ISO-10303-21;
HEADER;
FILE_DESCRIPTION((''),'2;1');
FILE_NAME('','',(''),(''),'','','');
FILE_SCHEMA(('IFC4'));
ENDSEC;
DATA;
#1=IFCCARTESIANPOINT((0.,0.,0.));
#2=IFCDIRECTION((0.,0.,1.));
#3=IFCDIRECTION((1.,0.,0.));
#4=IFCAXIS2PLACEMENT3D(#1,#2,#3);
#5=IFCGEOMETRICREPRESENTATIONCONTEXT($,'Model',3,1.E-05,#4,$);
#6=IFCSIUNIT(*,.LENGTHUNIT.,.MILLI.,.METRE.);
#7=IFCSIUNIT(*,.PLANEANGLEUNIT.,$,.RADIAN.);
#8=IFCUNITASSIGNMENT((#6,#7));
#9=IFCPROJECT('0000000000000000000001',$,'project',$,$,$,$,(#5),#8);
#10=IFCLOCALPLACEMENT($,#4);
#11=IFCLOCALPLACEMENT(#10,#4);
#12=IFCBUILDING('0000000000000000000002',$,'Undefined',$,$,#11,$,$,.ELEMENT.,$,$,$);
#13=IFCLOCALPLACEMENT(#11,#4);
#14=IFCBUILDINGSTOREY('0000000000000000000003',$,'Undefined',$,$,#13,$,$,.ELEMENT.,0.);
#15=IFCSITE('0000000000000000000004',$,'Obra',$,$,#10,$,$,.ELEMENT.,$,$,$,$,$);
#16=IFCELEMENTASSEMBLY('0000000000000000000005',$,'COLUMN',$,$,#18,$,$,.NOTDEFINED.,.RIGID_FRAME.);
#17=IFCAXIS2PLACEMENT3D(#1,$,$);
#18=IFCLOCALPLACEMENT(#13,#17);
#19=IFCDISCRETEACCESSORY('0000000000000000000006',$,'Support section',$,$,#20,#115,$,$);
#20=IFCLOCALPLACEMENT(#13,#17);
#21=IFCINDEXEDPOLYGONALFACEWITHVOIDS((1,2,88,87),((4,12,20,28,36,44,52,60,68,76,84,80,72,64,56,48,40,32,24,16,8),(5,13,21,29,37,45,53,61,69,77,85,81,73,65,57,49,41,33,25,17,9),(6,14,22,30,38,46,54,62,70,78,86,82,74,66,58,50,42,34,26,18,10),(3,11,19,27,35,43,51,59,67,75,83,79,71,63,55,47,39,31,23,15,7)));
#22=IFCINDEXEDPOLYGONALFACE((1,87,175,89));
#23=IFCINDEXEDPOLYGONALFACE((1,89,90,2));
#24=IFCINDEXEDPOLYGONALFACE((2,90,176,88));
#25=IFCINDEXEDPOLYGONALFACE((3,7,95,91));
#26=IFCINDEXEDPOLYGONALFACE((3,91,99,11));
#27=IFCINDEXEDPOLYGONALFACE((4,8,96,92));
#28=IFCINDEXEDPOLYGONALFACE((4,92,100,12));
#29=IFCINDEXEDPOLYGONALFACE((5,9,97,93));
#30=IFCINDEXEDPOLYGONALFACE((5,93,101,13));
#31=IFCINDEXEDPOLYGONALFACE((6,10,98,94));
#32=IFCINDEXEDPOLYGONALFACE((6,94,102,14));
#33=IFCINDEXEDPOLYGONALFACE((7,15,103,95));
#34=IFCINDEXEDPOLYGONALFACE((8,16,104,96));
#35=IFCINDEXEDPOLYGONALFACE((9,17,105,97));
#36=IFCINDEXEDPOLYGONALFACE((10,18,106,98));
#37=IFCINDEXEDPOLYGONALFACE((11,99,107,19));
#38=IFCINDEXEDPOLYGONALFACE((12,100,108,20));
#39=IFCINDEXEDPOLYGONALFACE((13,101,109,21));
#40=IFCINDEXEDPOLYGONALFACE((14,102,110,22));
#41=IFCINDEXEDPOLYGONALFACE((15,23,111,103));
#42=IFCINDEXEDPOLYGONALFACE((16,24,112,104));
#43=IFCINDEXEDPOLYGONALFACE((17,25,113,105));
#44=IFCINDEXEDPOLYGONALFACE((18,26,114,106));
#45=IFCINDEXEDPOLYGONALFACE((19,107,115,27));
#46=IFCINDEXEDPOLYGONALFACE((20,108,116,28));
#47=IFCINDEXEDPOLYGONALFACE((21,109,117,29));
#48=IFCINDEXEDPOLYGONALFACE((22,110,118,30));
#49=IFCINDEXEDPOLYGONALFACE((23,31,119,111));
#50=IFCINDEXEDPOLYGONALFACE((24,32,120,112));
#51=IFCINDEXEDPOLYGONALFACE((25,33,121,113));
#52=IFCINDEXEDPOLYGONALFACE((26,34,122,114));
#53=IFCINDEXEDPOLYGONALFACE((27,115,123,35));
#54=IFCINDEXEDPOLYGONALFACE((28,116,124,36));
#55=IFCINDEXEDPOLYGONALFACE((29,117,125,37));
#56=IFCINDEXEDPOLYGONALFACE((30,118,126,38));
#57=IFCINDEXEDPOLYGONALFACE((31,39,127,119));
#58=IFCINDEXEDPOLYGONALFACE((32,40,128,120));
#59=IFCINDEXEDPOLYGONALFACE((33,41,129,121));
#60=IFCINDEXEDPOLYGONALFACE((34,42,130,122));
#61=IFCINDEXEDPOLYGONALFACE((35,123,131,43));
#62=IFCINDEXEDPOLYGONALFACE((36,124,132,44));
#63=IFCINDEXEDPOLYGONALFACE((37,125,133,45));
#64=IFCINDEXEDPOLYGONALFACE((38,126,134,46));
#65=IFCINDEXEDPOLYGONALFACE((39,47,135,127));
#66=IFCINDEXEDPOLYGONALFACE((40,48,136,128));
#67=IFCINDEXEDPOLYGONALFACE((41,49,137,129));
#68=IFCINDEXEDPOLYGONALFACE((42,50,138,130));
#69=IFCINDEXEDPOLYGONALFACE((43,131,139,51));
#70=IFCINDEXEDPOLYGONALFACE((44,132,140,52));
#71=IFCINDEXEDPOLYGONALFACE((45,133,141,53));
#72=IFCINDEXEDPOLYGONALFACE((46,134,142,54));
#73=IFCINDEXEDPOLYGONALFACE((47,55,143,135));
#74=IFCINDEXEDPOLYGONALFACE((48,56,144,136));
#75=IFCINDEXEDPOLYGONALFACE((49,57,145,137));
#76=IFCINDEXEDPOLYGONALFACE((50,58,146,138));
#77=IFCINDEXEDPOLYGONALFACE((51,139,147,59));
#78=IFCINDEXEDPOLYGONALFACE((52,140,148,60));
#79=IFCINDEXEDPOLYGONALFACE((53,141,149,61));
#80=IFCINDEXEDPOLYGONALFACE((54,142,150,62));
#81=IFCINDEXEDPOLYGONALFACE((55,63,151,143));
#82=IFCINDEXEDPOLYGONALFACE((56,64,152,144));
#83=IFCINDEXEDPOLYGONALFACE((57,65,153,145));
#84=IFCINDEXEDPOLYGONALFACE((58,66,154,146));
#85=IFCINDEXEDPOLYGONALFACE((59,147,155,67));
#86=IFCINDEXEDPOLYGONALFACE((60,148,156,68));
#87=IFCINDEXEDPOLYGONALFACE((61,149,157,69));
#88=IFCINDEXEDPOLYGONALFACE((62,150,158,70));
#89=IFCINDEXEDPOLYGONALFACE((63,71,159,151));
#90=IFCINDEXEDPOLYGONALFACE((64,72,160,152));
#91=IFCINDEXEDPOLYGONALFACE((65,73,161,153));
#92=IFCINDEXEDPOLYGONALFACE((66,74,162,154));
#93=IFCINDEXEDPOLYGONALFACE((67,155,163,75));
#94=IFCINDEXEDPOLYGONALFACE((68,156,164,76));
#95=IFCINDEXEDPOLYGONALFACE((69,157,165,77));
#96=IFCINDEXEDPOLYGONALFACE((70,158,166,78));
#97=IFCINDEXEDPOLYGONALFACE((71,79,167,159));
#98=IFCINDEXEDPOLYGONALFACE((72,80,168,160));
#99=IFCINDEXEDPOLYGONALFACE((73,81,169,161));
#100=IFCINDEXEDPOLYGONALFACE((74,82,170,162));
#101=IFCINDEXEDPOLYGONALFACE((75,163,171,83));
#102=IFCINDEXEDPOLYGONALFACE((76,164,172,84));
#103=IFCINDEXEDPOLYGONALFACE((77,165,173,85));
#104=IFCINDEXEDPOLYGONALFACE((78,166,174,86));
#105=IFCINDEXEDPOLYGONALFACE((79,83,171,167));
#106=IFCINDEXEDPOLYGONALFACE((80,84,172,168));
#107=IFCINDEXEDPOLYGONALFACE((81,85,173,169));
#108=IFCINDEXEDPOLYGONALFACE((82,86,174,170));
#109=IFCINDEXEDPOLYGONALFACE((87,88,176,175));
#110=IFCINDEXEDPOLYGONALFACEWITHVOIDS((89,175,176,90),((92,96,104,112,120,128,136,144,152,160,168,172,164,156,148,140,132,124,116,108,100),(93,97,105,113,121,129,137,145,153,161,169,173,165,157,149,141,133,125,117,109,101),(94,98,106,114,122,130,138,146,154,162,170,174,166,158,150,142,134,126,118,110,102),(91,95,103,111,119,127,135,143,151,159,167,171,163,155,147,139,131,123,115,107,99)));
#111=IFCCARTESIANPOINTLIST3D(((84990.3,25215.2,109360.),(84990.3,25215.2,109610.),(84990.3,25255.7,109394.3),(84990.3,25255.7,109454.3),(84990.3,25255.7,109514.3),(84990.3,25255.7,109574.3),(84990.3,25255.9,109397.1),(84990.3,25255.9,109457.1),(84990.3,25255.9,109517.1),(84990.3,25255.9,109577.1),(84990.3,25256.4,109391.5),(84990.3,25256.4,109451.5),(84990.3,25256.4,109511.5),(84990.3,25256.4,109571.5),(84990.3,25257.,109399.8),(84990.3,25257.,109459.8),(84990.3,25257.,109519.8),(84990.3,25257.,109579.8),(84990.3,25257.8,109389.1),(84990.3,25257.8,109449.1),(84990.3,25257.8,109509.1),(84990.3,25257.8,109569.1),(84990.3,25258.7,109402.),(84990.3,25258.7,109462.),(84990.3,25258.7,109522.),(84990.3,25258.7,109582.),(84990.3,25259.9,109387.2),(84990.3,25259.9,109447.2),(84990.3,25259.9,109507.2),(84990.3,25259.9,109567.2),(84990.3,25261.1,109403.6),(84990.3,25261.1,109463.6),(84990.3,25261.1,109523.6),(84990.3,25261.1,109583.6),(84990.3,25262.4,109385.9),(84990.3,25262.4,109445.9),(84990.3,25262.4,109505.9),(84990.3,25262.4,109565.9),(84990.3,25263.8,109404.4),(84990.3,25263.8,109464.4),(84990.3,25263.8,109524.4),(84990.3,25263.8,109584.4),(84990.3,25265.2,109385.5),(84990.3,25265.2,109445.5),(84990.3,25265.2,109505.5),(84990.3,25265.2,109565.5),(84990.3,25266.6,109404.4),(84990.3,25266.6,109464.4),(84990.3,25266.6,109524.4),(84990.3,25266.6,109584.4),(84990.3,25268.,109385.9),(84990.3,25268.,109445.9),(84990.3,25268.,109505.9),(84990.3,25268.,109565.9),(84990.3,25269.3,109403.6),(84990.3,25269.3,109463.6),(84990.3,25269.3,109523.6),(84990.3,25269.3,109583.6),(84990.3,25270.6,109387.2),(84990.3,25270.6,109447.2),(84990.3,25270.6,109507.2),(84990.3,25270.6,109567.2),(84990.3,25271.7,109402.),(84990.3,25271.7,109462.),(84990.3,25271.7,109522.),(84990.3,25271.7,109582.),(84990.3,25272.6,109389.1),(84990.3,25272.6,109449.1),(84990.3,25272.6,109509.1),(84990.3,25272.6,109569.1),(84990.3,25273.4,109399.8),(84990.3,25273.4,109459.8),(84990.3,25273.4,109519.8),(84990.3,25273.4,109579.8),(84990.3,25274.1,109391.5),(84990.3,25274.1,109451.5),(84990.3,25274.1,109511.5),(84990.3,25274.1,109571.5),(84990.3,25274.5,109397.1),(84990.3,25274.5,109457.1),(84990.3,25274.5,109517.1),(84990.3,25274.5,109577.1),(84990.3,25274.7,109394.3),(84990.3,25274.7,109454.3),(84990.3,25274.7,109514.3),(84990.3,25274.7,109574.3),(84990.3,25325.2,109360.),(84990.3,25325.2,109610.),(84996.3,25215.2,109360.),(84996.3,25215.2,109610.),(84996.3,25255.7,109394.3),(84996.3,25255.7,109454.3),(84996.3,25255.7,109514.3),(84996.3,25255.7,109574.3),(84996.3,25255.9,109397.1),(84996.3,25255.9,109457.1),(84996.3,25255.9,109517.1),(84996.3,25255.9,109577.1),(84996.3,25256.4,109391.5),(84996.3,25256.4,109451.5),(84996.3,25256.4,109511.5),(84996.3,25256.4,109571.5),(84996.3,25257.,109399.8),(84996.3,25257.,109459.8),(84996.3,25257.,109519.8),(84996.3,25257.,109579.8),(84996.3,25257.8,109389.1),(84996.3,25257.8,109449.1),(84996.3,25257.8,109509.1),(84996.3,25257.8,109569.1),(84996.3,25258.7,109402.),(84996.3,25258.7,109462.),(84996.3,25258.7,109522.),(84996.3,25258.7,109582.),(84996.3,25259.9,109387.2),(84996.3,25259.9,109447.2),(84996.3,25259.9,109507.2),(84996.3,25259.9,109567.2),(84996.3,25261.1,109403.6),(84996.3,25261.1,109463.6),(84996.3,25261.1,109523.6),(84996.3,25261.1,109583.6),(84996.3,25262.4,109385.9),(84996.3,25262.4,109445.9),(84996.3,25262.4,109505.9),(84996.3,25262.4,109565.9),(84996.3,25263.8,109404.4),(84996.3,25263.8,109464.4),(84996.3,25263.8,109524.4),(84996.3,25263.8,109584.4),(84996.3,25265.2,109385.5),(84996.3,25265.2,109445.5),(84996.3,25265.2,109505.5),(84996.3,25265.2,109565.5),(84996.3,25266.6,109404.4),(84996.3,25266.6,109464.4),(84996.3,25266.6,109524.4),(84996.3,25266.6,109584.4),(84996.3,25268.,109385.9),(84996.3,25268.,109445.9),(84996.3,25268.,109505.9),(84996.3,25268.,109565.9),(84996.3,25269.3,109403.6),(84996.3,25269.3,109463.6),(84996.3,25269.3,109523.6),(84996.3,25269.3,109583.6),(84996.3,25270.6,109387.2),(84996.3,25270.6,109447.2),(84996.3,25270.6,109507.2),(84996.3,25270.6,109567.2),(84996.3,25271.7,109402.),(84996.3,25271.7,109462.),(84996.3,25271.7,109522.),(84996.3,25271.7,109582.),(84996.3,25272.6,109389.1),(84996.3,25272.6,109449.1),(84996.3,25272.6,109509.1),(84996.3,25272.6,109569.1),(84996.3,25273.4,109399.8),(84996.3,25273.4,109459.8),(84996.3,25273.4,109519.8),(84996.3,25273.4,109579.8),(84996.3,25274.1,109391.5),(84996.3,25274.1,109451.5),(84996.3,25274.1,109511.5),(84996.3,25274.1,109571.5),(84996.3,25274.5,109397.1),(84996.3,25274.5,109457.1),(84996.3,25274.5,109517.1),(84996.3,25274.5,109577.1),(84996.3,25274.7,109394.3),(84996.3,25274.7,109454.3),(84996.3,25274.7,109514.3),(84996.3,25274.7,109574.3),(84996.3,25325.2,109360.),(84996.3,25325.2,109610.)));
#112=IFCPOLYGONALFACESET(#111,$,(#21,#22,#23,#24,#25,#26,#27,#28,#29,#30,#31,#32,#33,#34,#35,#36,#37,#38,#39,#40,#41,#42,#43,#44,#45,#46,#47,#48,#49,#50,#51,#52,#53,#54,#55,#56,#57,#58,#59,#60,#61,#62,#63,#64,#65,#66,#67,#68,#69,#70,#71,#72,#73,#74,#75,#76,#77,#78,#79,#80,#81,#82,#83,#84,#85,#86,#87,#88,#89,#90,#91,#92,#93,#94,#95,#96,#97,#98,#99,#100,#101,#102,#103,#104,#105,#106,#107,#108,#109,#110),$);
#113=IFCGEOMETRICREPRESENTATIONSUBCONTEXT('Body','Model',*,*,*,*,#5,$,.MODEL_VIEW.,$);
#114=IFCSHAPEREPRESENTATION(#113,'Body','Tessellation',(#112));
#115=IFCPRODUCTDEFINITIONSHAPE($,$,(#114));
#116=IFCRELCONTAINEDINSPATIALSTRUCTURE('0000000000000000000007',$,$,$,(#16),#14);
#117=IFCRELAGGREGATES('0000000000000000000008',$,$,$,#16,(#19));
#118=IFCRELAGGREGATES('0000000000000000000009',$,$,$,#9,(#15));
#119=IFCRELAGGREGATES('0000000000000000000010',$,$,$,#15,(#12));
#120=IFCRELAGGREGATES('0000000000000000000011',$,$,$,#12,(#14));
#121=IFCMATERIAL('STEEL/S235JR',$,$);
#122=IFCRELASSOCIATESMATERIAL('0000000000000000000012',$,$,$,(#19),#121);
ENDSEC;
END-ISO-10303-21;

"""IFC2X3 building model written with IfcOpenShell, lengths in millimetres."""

from ifc_helpers import new_model, si_unit, frame, origin_with_axes, origin_2d_with_axis, place, context, subcontext, project, spatial, rectangle, circle, extrude, source, transform, mapped, material, element, aggregate, save


model = new_model("IFC2X3")

# Units and contexts
model_context = context("Model", 3, precision=1e-05, world=origin_with_axes())
body_context = subcontext(model_context, "Body", "Model", "MODEL_VIEW")
ifc_project = project(units=[si_unit("LENGTHUNIT", "METRE", prefix="MILLI"), si_unit("PLANEANGLEUNIT", "RADIAN")], contexts=[model_context])

# Site, building, storey
site_placement = place(None, origin_with_axes())
site = spatial("IfcSite", under=ifc_project, at=site_placement, Name="Obra", CompositionType="ELEMENT")
building_placement = place(site_placement, origin_with_axes())
building = spatial("IfcBuilding", under=site, at=building_placement, Name="Undefined", CompositionType="ELEMENT")
storey_placement = place(building_placement, origin_with_axes())
storey = spatial("IfcBuildingStorey", under=building, at=storey_placement, Name="Undefined", CompositionType="ELEMENT", Elevation=0.0)

# Element assembly
ifc_material_1 = material(Name="STEEL/S235JR")
assembly_1_placement = place(storey_placement, origin_with_axes())
assembly_1 = element("IfcElementAssembly", 1, at=assembly_1_placement, inside=storey, Name="COLUMN", AssemblyPlace="NOTDEFINED", PredefinedType="RIGID_FRAME")

# Discrete accessory, opening
shared_shape_1 = source(origin_with_axes(), body_context, "Body", "SweptSolid", [
    extrude(circle(Radius=9.5, at=origin_2d_with_axis()), frame((0.0, -9.8, 0.0), z_axis=(0.0, 1.0, 0.0), x_axis=(1.0, 0.0, 0.0)), (0.0, 0.0, 1.0), 6.2),
])
discrete_accessory_1_placement = place(assembly_1_placement, frame((84993.3, 25270.2, 109360.0), z_axis=(0.0, 0.0, 1.0), x_axis=(0.0, 1.0, 0.0)))
discrete_accessory_1 = element("IfcDiscreteAccessory", 2, at=discrete_accessory_1_placement, material=ifc_material_1, Name="Support section", context=body_context, shape_type="SweptSolid", body=[
    extrude(rectangle(XDim=6.0, YDim=110.0, at=origin_2d_with_axis()), frame((0.0, 0.0, 250.0), z_axis=(0.0, 0.0, -1.0), x_axis=(0.0, 1.0, 0.0)), (0.0, 0.0, 1.0), 250.0),
])
opening_1_placement = place(assembly_1_placement, frame((85000.0, 25315.2, 109650.0), z_axis=(0.0, -1.0, 0.0), x_axis=(0.0, 0.0, -1.0)))
element("IfcOpeningElement", 3, at=opening_1_placement, cuts=discrete_accessory_1, ObjectType="Opening", context=body_context, shape_type="MappedRepresentation", body=[
    mapped(shared_shape_1, transform((75.0, 0.0, 50.0))),
    mapped(shared_shape_1, transform((135.0, 0.0, 50.0))),
    mapped(shared_shape_1, transform((195.0, 0.0, 50.0))),
    mapped(shared_shape_1, transform((255.0, 0.0, 50.0))),
])
aggregate(assembly_1, [discrete_accessory_1])

save(model, "model.ifc")
